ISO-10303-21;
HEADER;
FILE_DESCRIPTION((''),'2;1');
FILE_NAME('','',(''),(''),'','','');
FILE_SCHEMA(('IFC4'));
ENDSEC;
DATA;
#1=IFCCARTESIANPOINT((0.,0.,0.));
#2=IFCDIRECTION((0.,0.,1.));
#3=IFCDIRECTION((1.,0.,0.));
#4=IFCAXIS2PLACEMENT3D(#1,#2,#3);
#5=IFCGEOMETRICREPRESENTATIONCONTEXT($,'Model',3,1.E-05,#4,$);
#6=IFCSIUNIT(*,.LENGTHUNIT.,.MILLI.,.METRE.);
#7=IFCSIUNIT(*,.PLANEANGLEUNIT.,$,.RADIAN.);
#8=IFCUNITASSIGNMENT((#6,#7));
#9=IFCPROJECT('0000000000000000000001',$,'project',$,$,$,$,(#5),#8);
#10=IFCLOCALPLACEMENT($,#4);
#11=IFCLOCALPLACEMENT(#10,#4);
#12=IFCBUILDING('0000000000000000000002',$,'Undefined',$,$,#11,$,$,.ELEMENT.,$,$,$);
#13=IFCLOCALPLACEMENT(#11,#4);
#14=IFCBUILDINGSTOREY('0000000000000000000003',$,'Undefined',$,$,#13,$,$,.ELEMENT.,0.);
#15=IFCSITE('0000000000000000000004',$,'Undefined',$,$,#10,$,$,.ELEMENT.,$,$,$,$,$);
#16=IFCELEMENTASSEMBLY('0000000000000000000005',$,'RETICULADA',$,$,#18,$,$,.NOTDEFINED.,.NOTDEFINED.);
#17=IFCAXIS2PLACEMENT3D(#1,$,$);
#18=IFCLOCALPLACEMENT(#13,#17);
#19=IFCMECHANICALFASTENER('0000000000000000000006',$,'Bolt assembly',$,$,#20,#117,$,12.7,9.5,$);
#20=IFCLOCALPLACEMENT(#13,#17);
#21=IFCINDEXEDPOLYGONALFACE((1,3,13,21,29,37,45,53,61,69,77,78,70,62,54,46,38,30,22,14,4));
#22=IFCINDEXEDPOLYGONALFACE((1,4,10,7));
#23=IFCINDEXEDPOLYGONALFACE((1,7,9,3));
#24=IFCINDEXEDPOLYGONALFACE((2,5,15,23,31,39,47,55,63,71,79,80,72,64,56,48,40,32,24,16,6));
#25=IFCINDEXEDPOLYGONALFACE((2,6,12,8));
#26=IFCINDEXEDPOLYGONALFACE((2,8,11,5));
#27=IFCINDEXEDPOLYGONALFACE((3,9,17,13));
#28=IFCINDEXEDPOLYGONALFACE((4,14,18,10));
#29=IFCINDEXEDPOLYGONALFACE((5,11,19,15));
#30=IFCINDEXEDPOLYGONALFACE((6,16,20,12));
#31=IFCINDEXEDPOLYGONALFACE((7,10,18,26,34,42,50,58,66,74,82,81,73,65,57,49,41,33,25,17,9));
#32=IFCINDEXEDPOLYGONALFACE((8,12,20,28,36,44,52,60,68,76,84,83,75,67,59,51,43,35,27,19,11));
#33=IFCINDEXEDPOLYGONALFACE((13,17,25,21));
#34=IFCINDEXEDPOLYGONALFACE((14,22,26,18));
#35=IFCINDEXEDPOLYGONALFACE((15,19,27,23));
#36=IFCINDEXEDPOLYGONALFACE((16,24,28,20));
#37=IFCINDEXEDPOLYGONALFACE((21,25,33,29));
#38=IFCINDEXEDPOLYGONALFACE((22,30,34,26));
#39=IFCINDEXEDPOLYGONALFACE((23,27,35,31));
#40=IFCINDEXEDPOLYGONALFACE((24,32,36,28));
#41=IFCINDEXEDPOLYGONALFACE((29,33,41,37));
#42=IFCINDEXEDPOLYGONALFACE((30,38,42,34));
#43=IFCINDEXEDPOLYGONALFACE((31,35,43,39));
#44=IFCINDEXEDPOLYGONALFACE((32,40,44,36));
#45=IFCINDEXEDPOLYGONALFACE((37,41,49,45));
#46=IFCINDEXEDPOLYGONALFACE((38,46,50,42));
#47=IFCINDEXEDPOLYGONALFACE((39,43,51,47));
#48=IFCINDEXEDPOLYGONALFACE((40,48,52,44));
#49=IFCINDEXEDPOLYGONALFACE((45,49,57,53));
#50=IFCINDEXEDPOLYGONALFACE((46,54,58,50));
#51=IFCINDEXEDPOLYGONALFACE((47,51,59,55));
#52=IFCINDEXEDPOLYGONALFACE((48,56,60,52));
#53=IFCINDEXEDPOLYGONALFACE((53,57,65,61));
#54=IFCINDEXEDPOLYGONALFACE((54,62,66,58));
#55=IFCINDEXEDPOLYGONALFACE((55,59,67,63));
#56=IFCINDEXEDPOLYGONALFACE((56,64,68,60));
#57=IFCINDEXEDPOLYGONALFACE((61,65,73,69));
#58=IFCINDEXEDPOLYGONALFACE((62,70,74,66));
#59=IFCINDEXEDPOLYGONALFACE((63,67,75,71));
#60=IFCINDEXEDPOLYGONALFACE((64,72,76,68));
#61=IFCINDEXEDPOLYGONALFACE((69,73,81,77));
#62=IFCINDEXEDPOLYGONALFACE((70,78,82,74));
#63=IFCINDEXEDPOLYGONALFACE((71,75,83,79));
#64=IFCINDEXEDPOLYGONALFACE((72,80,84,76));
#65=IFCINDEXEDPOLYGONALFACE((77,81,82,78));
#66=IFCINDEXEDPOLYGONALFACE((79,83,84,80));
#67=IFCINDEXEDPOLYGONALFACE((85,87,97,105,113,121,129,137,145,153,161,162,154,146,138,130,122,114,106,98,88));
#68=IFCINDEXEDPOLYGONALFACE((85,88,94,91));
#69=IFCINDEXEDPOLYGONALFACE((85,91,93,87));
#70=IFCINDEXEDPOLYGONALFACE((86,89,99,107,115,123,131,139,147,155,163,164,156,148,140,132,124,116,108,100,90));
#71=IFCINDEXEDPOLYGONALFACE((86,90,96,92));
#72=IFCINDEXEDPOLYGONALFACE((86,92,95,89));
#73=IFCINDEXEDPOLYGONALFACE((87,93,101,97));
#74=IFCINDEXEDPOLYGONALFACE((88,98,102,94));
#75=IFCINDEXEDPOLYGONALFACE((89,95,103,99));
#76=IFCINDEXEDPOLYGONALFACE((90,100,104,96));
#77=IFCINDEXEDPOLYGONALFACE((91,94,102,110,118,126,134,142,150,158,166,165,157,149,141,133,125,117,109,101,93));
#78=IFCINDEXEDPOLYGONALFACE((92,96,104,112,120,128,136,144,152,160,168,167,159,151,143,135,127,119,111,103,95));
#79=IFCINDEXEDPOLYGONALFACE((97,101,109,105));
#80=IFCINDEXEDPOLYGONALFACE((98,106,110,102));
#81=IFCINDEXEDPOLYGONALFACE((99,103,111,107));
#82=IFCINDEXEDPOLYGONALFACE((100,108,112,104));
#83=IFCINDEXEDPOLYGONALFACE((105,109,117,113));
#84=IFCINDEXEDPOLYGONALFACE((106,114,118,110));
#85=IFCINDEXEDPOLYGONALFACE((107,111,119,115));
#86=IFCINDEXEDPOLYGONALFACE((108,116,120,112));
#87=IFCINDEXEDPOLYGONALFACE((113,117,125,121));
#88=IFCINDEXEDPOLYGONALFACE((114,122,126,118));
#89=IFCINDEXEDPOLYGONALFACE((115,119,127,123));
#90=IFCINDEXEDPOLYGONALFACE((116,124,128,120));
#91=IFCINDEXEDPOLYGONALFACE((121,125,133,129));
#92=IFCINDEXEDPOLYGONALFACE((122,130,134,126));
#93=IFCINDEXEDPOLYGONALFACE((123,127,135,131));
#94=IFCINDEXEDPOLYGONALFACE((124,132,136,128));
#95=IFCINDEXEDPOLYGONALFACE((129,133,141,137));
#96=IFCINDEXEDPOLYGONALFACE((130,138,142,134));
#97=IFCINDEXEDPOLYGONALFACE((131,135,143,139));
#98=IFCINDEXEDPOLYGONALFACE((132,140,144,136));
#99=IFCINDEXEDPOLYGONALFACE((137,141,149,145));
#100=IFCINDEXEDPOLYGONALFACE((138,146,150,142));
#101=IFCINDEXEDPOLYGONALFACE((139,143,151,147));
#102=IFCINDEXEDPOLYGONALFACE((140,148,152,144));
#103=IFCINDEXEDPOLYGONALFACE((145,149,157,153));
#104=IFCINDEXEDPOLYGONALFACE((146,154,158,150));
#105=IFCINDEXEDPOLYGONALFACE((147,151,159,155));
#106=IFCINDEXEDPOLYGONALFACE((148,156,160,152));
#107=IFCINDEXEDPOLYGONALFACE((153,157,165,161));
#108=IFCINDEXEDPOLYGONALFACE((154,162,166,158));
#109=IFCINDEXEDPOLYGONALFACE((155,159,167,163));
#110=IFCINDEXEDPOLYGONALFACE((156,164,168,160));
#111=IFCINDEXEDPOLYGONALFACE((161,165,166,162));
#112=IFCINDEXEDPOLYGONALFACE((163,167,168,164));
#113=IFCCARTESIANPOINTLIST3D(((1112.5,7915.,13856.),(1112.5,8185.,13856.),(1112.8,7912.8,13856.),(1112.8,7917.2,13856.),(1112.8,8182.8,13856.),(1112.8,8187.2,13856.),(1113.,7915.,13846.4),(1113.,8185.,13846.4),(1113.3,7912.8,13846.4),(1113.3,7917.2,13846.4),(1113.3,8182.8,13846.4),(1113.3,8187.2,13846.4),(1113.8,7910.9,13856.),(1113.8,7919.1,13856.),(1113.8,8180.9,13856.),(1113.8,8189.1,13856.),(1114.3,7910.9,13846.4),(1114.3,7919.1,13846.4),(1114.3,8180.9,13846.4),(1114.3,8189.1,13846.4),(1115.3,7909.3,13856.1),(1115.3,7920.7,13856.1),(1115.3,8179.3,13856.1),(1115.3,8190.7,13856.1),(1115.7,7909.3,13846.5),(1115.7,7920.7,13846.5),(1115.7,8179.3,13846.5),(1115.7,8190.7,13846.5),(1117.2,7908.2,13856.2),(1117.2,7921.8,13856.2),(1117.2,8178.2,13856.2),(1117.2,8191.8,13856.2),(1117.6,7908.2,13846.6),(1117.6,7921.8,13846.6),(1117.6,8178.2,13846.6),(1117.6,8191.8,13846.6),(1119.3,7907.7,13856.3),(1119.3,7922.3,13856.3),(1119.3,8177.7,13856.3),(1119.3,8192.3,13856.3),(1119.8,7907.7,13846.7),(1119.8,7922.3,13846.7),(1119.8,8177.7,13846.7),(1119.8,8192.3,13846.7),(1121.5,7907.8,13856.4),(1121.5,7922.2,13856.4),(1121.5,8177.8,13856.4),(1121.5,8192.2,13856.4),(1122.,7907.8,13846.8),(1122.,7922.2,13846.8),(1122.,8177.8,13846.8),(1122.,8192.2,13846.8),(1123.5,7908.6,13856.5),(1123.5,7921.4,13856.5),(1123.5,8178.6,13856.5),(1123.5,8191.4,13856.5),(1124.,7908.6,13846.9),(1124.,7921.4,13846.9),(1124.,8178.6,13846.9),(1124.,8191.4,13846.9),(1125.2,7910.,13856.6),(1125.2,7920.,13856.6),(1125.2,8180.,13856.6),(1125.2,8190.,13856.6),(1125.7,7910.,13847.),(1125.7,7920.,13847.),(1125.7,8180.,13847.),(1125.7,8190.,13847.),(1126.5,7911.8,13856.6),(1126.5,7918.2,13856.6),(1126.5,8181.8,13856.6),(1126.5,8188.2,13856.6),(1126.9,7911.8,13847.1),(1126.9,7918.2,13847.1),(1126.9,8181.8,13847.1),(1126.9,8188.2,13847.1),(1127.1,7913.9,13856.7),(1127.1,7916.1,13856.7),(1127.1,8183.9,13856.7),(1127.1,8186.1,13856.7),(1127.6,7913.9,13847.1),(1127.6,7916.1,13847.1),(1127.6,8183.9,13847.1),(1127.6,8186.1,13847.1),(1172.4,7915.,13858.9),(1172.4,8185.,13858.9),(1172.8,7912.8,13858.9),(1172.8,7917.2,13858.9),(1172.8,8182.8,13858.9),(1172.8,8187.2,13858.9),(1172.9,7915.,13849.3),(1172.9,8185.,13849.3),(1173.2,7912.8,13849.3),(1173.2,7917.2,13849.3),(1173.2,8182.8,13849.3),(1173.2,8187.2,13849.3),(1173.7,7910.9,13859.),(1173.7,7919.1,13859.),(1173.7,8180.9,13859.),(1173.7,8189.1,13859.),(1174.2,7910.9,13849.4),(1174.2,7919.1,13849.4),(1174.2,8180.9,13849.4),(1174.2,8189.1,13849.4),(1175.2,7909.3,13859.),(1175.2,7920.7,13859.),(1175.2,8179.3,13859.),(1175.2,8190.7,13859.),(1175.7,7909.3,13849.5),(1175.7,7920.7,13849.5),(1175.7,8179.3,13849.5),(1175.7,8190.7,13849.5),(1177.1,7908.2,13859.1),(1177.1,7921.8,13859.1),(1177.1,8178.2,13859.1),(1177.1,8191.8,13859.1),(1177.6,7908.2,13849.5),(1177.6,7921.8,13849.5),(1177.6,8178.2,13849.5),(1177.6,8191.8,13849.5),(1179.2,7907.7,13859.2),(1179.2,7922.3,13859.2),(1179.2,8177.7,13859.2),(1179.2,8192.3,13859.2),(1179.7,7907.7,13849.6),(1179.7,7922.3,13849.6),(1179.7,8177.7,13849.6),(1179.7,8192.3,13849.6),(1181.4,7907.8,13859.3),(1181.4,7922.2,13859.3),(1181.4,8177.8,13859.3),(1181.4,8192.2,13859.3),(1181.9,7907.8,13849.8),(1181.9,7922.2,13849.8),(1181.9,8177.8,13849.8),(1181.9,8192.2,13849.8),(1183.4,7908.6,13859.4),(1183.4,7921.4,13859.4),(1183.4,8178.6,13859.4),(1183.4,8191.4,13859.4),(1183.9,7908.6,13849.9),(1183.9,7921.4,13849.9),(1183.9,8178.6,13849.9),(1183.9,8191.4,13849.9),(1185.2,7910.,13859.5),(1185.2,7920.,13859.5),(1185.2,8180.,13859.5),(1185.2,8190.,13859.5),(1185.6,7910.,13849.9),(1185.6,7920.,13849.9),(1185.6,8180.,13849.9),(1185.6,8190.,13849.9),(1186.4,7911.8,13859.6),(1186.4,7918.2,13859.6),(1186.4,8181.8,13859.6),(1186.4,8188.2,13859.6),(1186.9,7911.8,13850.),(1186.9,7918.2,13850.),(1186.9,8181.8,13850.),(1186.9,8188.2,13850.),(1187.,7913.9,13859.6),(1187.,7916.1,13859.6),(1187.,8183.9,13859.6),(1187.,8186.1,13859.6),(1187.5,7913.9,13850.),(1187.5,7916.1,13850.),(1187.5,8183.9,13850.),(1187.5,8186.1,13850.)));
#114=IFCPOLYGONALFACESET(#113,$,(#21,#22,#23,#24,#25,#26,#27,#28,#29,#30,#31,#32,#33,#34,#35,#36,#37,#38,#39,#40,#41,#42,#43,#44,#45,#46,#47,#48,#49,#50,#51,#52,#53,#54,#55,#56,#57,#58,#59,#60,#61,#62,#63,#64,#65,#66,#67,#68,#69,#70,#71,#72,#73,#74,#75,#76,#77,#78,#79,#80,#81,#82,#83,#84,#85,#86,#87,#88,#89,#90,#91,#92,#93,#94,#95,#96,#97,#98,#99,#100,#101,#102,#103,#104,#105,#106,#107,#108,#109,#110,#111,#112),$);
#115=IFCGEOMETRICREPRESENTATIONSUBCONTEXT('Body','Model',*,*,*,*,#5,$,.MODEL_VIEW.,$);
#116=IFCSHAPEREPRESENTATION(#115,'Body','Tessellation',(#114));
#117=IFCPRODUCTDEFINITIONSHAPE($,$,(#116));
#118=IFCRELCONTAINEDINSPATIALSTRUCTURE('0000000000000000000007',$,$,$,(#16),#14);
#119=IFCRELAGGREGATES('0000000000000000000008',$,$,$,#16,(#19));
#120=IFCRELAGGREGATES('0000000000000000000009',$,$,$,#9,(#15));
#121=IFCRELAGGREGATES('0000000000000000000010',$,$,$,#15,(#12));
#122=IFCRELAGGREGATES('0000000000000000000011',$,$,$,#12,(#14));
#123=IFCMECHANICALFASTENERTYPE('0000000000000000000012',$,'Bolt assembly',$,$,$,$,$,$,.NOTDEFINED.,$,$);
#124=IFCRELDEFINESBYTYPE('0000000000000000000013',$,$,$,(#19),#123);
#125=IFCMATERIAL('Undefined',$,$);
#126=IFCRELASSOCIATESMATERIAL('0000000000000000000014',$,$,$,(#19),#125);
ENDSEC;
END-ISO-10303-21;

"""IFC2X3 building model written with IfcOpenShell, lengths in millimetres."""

from ifc_helpers import new_model, si_unit, frame, origin_with_axes, origin_2d_with_axis, place, context, subcontext, project, spatial, circle, extrude, source, transform, mapped, material, type_object, element, aggregate, save


model = new_model("IFC2X3")

# Units and contexts
model_context = context("Model", 3, precision=1e-05, world=origin_with_axes())
body_context = subcontext(model_context, "Body", "Model", "MODEL_VIEW")
ifc_project = project(units=[si_unit("LENGTHUNIT", "METRE", prefix="MILLI"), si_unit("PLANEANGLEUNIT", "RADIAN")], contexts=[model_context])

# Site, building, storey
site_placement = place(None, origin_with_axes())
site = spatial("IfcSite", under=ifc_project, at=site_placement, Name="Undefined", CompositionType="ELEMENT")
building_placement = place(site_placement, origin_with_axes())
building = spatial("IfcBuilding", under=site, at=building_placement, Name="Undefined", CompositionType="ELEMENT")
storey_placement = place(building_placement, origin_with_axes())
storey = spatial("IfcBuildingStorey", under=building, at=storey_placement, Name="Undefined", CompositionType="ELEMENT", Elevation=0.0)

# Element assembly
assembly_1_placement = place(storey_placement, origin_with_axes())
assembly_1 = element("IfcElementAssembly", 1, at=assembly_1_placement, inside=storey, Name="RETICULADA", AssemblyPlace="NOTDEFINED", PredefinedType="NOTDEFINED")

# Mechanical fastener
ifc_material_1 = material(Name="Undefined")
mechanical_fastener_type = type_object("IfcMechanicalFastenerType", Name="Bolt assembly")
shared_shape_1 = source(origin_with_axes(), body_context, "Body", "SweptSolid", [
    extrude(circle(Radius=7.3, at=origin_2d_with_axis()), frame((0.0, 0.0, 0.0), z_axis=(0.0, 1.0, 0.0), x_axis=(1.0, 0.0, 0.0)), (0.0, 0.0, 1.0), 9.6),
])
mechanical_fastener_1_placement = place(assembly_1_placement, frame((1179.8, 8050.0, 13859.3), z_axis=(0.0, -1.0, 0.0), x_axis=(-0.998794, 0.0, -0.049094)))
mechanical_fastener_1 = element("IfcMechanicalFastener", 2, at=mechanical_fastener_1_placement, type_object=mechanical_fastener_type, material=ifc_material_1, Name="Bolt assembly", NominalDiameter=12.7, NominalLength=9.5, context=body_context, shape_type="MappedRepresentation", body=[
    mapped(shared_shape_1, transform((0.0, 0.0, -135.0))),
    mapped(shared_shape_1, transform((60.0, 0.0, -135.0))),
    mapped(shared_shape_1, transform((0.0, 0.0, 135.0))),
    mapped(shared_shape_1, transform((60.0, 0.0, 135.0))),
])
aggregate(assembly_1, [mechanical_fastener_1])

save(model, "model.ifc")
